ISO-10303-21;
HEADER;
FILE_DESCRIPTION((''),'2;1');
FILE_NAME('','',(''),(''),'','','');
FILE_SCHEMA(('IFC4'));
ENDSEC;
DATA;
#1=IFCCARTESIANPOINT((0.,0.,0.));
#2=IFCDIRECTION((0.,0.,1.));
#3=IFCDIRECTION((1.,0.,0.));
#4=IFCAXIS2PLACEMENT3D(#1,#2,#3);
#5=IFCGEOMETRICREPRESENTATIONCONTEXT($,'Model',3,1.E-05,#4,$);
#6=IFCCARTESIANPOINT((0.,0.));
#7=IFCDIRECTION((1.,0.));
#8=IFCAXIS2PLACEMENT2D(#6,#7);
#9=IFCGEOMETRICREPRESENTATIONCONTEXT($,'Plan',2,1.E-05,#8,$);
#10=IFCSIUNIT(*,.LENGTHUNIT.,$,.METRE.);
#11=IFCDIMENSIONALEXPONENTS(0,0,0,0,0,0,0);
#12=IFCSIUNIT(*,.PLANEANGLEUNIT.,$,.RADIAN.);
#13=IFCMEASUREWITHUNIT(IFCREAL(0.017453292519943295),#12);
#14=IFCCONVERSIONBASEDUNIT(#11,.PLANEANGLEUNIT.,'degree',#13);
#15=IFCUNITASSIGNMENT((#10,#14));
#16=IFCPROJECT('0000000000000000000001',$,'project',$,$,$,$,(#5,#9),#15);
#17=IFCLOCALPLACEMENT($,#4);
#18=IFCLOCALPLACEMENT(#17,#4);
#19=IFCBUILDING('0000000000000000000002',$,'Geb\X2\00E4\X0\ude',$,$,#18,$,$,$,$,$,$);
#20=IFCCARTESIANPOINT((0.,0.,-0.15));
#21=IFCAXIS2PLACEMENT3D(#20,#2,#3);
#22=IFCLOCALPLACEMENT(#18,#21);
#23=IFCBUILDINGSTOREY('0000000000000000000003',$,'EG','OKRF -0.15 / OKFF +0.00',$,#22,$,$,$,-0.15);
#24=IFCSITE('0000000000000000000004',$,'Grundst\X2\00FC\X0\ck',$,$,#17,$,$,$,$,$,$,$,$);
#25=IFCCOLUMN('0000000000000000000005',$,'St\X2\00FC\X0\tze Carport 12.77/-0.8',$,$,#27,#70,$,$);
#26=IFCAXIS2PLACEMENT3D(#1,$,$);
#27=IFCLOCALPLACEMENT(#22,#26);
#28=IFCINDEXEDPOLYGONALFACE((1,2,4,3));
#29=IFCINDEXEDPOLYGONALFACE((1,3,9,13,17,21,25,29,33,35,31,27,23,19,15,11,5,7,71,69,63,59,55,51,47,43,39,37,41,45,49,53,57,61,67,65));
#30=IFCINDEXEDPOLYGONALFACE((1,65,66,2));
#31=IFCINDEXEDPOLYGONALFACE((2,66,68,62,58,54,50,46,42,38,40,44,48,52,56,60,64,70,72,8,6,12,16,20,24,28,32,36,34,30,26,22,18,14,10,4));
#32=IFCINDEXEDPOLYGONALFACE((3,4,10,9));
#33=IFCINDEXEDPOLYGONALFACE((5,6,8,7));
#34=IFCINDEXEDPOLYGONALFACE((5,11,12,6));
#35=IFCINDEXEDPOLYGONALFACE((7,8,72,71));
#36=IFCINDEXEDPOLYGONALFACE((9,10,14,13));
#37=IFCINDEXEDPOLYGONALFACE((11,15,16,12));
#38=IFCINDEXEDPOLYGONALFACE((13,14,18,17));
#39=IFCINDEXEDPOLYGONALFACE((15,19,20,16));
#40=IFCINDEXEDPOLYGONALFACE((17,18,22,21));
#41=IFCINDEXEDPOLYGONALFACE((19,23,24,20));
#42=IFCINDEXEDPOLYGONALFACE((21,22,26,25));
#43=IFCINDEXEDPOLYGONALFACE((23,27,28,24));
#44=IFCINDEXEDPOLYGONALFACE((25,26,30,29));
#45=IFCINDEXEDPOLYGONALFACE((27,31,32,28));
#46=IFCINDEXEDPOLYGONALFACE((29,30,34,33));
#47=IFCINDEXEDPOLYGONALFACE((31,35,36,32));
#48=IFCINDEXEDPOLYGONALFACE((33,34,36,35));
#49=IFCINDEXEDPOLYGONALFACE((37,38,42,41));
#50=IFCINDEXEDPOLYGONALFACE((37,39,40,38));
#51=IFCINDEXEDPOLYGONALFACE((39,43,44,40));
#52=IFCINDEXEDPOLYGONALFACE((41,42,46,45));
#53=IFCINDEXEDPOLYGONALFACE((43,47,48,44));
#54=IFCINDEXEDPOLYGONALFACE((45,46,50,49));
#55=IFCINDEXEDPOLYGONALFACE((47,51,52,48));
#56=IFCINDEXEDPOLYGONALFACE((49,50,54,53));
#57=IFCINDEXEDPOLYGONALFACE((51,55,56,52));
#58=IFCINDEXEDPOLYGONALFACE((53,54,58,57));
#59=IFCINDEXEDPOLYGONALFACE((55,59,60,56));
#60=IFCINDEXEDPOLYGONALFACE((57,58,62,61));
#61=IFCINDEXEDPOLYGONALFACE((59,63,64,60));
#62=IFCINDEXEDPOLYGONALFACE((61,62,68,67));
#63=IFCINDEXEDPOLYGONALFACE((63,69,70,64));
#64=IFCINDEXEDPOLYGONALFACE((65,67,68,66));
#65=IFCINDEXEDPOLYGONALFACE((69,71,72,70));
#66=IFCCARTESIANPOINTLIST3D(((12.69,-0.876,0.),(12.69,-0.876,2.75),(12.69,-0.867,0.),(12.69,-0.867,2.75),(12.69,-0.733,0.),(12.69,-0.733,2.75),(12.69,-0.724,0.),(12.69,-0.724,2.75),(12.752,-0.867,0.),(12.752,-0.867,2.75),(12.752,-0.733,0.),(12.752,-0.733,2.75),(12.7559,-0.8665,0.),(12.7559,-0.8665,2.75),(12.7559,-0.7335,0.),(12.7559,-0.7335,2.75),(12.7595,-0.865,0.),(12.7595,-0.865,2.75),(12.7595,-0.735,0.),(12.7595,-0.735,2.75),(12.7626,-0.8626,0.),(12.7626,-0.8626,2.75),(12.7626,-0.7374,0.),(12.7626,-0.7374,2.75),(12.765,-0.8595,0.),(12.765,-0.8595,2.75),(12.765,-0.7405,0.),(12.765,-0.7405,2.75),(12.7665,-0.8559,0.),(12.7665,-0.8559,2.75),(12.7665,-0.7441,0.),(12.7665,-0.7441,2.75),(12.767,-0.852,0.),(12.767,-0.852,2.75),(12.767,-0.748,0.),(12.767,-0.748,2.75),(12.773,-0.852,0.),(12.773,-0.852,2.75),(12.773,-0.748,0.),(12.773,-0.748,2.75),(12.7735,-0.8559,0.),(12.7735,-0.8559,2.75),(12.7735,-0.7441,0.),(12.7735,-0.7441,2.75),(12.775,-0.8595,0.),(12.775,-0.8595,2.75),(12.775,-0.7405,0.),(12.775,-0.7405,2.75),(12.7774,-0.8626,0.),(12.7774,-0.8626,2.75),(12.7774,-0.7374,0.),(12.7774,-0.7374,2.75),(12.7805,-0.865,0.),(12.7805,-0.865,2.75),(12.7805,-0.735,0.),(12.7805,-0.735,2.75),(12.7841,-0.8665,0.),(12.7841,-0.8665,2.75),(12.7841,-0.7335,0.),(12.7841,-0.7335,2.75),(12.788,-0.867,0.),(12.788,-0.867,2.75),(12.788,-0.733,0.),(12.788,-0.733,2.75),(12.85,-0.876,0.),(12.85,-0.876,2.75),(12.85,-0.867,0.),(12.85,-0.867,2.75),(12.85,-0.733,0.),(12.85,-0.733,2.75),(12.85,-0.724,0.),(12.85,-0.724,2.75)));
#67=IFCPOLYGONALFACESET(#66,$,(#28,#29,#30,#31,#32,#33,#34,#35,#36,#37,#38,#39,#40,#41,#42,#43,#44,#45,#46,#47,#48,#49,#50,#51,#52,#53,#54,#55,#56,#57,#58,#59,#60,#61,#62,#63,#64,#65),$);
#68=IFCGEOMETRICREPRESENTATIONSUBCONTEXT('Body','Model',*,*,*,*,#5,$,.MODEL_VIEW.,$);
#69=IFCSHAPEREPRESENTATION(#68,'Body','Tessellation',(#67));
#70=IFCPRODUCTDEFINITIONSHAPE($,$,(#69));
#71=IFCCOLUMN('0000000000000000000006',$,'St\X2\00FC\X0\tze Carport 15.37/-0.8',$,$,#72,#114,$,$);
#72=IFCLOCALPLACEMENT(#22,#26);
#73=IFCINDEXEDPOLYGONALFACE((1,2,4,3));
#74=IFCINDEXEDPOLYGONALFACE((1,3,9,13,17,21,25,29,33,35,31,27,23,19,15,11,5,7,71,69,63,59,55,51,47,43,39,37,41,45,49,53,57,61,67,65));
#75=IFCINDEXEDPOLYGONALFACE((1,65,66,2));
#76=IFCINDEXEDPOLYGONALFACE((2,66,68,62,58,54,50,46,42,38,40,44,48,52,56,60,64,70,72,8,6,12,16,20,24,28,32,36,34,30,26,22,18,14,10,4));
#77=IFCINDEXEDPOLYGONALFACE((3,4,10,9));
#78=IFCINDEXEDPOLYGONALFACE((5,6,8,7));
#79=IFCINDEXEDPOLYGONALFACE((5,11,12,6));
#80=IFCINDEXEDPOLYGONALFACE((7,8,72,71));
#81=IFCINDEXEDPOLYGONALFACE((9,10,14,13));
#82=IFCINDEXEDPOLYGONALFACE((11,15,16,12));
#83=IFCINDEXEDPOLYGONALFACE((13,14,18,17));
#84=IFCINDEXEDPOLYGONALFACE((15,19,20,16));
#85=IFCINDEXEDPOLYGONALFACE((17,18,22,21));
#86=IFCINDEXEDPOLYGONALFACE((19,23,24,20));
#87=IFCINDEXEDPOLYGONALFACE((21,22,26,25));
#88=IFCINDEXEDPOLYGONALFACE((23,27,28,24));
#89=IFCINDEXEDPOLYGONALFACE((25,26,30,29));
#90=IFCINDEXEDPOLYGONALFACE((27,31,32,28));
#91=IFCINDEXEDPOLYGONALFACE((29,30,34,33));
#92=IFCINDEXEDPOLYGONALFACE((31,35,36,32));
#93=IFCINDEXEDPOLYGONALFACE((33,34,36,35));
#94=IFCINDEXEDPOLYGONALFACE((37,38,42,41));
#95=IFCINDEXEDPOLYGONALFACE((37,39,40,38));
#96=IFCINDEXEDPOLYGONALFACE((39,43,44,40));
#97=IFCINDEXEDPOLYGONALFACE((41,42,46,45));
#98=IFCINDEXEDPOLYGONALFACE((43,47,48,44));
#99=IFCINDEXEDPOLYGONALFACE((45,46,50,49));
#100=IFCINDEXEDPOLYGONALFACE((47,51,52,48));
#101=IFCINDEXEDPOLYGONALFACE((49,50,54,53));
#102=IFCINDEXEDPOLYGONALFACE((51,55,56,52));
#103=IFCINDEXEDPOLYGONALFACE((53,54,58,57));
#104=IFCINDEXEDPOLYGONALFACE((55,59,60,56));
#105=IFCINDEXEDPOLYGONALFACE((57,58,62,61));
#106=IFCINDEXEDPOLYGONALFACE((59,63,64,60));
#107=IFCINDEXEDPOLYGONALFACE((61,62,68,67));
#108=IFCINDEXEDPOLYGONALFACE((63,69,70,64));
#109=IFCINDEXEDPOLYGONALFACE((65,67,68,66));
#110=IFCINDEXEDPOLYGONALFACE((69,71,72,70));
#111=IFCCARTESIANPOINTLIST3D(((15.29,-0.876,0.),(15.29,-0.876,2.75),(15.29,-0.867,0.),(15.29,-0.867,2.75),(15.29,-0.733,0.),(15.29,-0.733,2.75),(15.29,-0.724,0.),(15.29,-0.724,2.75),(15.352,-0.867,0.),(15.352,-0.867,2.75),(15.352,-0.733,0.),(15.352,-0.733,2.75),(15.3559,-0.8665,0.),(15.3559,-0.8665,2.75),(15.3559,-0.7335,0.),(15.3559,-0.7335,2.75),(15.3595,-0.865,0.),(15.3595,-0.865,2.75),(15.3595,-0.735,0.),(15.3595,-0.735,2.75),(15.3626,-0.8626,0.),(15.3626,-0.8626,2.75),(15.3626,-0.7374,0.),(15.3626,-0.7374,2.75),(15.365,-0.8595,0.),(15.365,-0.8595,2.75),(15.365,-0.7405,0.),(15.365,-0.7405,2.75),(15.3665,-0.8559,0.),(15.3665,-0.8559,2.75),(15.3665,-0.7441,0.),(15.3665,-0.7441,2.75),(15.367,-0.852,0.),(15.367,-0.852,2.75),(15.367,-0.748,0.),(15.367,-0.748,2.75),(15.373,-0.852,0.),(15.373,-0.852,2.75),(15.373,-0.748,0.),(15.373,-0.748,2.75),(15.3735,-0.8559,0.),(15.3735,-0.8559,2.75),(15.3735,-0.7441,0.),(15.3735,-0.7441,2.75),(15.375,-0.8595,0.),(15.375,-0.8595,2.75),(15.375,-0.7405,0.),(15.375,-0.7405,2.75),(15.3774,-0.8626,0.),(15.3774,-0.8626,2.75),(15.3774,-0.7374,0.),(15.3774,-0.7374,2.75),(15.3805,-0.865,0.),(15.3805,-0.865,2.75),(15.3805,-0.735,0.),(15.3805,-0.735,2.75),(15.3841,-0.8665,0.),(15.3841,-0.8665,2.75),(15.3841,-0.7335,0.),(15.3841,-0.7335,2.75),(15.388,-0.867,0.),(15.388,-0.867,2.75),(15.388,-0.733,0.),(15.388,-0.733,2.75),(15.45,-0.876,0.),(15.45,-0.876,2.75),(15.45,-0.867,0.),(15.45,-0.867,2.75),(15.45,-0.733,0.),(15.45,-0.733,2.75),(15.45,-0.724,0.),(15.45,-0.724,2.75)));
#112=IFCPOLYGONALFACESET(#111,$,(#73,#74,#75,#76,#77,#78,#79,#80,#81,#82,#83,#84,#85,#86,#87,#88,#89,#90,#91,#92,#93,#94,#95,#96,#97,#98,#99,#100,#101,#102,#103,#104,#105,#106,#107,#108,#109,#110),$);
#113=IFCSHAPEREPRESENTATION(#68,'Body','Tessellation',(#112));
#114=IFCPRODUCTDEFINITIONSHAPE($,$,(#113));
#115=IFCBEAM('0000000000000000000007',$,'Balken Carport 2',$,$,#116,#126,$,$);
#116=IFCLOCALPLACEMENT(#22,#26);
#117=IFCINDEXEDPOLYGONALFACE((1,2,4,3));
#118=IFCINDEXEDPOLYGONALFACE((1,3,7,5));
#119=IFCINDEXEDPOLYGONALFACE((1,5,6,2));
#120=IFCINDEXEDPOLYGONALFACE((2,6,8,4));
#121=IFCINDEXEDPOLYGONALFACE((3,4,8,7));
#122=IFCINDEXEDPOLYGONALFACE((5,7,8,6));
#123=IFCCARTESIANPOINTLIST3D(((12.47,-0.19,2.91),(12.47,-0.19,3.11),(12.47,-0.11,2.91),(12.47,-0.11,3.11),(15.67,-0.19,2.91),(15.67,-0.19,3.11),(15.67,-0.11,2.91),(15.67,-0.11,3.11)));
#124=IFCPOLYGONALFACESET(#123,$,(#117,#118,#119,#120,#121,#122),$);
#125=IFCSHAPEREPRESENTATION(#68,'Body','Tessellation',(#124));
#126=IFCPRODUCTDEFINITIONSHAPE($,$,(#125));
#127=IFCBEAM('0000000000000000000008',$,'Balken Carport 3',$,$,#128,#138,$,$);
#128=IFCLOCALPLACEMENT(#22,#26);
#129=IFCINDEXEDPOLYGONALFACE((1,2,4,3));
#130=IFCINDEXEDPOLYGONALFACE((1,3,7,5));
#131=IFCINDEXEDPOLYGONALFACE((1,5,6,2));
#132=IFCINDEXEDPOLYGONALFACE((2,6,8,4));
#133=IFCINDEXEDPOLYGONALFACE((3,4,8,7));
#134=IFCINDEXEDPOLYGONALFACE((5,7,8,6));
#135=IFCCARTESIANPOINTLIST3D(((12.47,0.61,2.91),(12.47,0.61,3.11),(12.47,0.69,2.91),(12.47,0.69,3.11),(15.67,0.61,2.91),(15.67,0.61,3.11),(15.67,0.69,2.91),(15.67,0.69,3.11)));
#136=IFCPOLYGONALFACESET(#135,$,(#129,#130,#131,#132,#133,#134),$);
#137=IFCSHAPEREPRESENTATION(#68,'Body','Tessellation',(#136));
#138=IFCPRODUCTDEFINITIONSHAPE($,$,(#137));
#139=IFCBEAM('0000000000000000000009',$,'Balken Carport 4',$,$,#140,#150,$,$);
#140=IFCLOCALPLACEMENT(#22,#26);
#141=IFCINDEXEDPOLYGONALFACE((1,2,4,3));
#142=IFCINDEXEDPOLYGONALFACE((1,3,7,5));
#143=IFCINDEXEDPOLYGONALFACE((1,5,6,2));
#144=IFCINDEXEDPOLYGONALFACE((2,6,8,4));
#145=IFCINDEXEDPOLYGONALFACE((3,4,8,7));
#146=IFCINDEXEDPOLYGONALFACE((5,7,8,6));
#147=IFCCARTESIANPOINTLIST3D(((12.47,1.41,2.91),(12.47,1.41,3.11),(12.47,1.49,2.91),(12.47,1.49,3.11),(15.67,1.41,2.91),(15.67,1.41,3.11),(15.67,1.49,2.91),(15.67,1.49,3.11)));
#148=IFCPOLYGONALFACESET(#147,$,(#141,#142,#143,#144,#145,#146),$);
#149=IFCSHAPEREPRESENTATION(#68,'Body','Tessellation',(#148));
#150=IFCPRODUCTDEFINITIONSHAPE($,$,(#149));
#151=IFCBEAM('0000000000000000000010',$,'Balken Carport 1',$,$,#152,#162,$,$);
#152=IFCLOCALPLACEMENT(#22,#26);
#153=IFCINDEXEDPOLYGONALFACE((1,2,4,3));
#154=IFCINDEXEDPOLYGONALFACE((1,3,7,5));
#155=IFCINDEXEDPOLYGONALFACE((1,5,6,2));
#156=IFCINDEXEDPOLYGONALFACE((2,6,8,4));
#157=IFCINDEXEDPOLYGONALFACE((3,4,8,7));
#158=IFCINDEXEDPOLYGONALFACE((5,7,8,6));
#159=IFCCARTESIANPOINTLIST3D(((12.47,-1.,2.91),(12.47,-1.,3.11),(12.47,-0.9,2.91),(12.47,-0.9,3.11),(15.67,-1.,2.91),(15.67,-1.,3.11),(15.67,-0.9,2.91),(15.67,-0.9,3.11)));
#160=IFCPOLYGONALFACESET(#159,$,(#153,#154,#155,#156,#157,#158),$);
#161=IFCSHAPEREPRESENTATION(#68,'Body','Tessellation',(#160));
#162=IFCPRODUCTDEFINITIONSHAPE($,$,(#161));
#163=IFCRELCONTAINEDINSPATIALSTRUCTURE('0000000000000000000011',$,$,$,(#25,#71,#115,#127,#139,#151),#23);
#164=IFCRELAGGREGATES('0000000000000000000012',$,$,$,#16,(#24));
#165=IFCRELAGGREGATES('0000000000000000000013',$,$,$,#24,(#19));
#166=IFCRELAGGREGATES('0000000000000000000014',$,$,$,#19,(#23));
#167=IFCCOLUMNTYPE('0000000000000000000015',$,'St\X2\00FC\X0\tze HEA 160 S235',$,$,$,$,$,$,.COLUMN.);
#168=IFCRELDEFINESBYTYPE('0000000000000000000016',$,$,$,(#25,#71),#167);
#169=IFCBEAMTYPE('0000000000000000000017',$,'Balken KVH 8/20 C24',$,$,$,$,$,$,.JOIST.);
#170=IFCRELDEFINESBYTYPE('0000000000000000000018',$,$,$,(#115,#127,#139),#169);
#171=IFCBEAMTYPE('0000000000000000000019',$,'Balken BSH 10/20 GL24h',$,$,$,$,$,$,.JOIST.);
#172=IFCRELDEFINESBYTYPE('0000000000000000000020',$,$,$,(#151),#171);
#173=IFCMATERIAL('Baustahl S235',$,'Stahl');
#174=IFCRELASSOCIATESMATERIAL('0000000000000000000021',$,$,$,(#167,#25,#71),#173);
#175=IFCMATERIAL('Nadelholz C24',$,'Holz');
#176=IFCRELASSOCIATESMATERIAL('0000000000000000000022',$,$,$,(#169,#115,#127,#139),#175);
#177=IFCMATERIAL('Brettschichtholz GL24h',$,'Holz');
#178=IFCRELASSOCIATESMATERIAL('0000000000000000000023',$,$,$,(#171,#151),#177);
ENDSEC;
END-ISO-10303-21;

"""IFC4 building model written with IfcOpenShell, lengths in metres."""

from ifc_helpers import new_model, entity, si_unit, converted_unit, frame, origin_with_axes, origin_2d_with_axis, place, context, subcontext, project, spatial, rectangle, i_section, extrude, material, material_profile, profile_set, profile_usage, type_object, element, save


model = new_model("IFC4")

# Units and contexts
model_context = context("Model", 3, precision=1e-05, world=origin_with_axes())
plan_context = context("Plan", 2, precision=1e-05, world=origin_2d_with_axis())
body_context = subcontext(model_context, "Body", "Model", "MODEL_VIEW")
ifc_project = project(units=[si_unit("LENGTHUNIT", "METRE"), converted_unit("PLANEANGLEUNIT", "degree", entity("IfcReal", 0.017453292519943295), si_unit("PLANEANGLEUNIT", "RADIAN"), dimensions=[0, 0, 0, 0, 0, 0, 0])], contexts=[model_context, plan_context])

# Site, building, storey
site_placement = place(None, origin_with_axes())
site = spatial("IfcSite", under=ifc_project, at=site_placement, Name="Grundstück")
building_placement = place(site_placement, origin_with_axes())
building = spatial("IfcBuilding", under=site, at=building_placement, Name="Gebäude")
storey_placement = place(building_placement, frame((0.0, 0.0, -0.15), z_axis=(0.0, 0.0, 1.0), x_axis=(1.0, 0.0, 0.0)))
storey = spatial("IfcBuildingStorey", under=building, at=storey_placement, Name="EG", Description="OKRF -0.15 / OKFF +0.00", Elevation=-0.15)

# Columns
ifc_material_1 = material(Name="Baustahl S235", Category="Stahl")
ifc_material_profile_1 = material_profile(ifc_material_1, i_section(OverallWidth=0.16, OverallDepth=0.152, WebThickness=0.006, FlangeThickness=0.009, FilletRadius=0.015))
ifc_profile_set_1 = profile_set([ifc_material_profile_1], Name="Stütze HEA 160 S235")
ifc_profile_usage_1 = profile_usage(ifc_profile_set_1)
column_type_1 = type_object("IfcColumnType", Name="Stütze HEA 160 S235", PredefinedType="COLUMN", material=ifc_profile_set_1)
column_1_placement = place(storey_placement, frame((12.77, -0.8, 0.0), z_axis=(0.0, 0.0, 1.0), x_axis=(1.0, 0.0, 0.0)))
element("IfcColumn", 1, at=column_1_placement, inside=storey, type_object=column_type_1, material=ifc_profile_usage_1, Name="Stütze Carport 12.77/-0.8", context=body_context, shape_type="SweptSolid", body=[
    extrude(i_section(OverallWidth=0.16, OverallDepth=0.152, WebThickness=0.006, FlangeThickness=0.009, FilletRadius=0.015), origin_with_axes(), (0.0, 0.0, 1.0), 2.75),
])
ifc_profile_usage_2 = profile_usage(ifc_profile_set_1)
column_2_placement = place(storey_placement, frame((15.37, -0.8, 0.0), z_axis=(0.0, 0.0, 1.0), x_axis=(1.0, 0.0, 0.0)))
element("IfcColumn", 2, at=column_2_placement, inside=storey, type_object=column_type_1, material=ifc_profile_usage_2, Name="Stütze Carport 15.37/-0.8", context=body_context, shape_type="SweptSolid", body=[
    extrude(i_section(OverallWidth=0.16, OverallDepth=0.152, WebThickness=0.006, FlangeThickness=0.009, FilletRadius=0.015), origin_with_axes(), (0.0, 0.0, 1.0), 2.75),
])

# Beams
ifc_material_2 = material(Name="Nadelholz C24", Category="Holz")
ifc_material_profile_2 = material_profile(ifc_material_2, rectangle(XDim=0.08, YDim=0.2))
ifc_profile_set_2 = profile_set([ifc_material_profile_2], Name="Balken KVH 8/20 C24")
ifc_profile_usage_3 = profile_usage(ifc_profile_set_2)
beam_type_1 = type_object("IfcBeamType", Name="Balken KVH 8/20 C24", PredefinedType="JOIST", material=ifc_profile_set_2)
beam_1_placement = place(storey_placement, frame((12.47, -0.15, 3.01), z_axis=(1.0, 0.0, 0.0), x_axis=(0.0, 1.0, 0.0)))
element("IfcBeam", 3, at=beam_1_placement, inside=storey, type_object=beam_type_1, material=ifc_profile_usage_3, Name="Balken Carport 2", context=body_context, shape_type="SweptSolid", body=[
    extrude(rectangle(XDim=0.08, YDim=0.2), origin_with_axes(), (0.0, 0.0, 1.0), 3.2),
])
ifc_profile_usage_4 = profile_usage(ifc_profile_set_2)
beam_2_placement = place(storey_placement, frame((12.47, 0.65, 3.01), z_axis=(1.0, 0.0, 0.0), x_axis=(0.0, 1.0, 0.0)))
element("IfcBeam", 4, at=beam_2_placement, inside=storey, type_object=beam_type_1, material=ifc_profile_usage_4, Name="Balken Carport 3", context=body_context, shape_type="SweptSolid", body=[
    extrude(rectangle(XDim=0.08, YDim=0.2), origin_with_axes(), (0.0, 0.0, 1.0), 3.2),
])
ifc_profile_usage_5 = profile_usage(ifc_profile_set_2)
beam_3_placement = place(storey_placement, frame((12.47, 1.45, 3.01), z_axis=(1.0, 0.0, 0.0), x_axis=(0.0, 1.0, 0.0)))
element("IfcBeam", 5, at=beam_3_placement, inside=storey, type_object=beam_type_1, material=ifc_profile_usage_5, Name="Balken Carport 4", context=body_context, shape_type="SweptSolid", body=[
    extrude(rectangle(XDim=0.08, YDim=0.2), origin_with_axes(), (0.0, 0.0, 1.0), 3.2),
])
ifc_material_3 = material(Name="Brettschichtholz GL24h", Category="Holz")
ifc_material_profile_3 = material_profile(ifc_material_3, rectangle(XDim=0.1, YDim=0.2))
ifc_profile_set_3 = profile_set([ifc_material_profile_3], Name="Balken BSH 10/20 GL24h")
ifc_profile_usage_6 = profile_usage(ifc_profile_set_3)
beam_type_2 = type_object("IfcBeamType", Name="Balken BSH 10/20 GL24h", PredefinedType="JOIST", material=ifc_profile_set_3)
beam_4_placement = place(storey_placement, frame((12.47, -0.95, 3.01), z_axis=(1.0, 0.0, 0.0), x_axis=(0.0, 1.0, 0.0)))
element("IfcBeam", 6, at=beam_4_placement, inside=storey, type_object=beam_type_2, material=ifc_profile_usage_6, Name="Balken Carport 1", context=body_context, shape_type="SweptSolid", body=[
    extrude(rectangle(XDim=0.1, YDim=0.2), origin_with_axes(), (0.0, 0.0, 1.0), 3.2),
])

save(model, "model.ifc")
